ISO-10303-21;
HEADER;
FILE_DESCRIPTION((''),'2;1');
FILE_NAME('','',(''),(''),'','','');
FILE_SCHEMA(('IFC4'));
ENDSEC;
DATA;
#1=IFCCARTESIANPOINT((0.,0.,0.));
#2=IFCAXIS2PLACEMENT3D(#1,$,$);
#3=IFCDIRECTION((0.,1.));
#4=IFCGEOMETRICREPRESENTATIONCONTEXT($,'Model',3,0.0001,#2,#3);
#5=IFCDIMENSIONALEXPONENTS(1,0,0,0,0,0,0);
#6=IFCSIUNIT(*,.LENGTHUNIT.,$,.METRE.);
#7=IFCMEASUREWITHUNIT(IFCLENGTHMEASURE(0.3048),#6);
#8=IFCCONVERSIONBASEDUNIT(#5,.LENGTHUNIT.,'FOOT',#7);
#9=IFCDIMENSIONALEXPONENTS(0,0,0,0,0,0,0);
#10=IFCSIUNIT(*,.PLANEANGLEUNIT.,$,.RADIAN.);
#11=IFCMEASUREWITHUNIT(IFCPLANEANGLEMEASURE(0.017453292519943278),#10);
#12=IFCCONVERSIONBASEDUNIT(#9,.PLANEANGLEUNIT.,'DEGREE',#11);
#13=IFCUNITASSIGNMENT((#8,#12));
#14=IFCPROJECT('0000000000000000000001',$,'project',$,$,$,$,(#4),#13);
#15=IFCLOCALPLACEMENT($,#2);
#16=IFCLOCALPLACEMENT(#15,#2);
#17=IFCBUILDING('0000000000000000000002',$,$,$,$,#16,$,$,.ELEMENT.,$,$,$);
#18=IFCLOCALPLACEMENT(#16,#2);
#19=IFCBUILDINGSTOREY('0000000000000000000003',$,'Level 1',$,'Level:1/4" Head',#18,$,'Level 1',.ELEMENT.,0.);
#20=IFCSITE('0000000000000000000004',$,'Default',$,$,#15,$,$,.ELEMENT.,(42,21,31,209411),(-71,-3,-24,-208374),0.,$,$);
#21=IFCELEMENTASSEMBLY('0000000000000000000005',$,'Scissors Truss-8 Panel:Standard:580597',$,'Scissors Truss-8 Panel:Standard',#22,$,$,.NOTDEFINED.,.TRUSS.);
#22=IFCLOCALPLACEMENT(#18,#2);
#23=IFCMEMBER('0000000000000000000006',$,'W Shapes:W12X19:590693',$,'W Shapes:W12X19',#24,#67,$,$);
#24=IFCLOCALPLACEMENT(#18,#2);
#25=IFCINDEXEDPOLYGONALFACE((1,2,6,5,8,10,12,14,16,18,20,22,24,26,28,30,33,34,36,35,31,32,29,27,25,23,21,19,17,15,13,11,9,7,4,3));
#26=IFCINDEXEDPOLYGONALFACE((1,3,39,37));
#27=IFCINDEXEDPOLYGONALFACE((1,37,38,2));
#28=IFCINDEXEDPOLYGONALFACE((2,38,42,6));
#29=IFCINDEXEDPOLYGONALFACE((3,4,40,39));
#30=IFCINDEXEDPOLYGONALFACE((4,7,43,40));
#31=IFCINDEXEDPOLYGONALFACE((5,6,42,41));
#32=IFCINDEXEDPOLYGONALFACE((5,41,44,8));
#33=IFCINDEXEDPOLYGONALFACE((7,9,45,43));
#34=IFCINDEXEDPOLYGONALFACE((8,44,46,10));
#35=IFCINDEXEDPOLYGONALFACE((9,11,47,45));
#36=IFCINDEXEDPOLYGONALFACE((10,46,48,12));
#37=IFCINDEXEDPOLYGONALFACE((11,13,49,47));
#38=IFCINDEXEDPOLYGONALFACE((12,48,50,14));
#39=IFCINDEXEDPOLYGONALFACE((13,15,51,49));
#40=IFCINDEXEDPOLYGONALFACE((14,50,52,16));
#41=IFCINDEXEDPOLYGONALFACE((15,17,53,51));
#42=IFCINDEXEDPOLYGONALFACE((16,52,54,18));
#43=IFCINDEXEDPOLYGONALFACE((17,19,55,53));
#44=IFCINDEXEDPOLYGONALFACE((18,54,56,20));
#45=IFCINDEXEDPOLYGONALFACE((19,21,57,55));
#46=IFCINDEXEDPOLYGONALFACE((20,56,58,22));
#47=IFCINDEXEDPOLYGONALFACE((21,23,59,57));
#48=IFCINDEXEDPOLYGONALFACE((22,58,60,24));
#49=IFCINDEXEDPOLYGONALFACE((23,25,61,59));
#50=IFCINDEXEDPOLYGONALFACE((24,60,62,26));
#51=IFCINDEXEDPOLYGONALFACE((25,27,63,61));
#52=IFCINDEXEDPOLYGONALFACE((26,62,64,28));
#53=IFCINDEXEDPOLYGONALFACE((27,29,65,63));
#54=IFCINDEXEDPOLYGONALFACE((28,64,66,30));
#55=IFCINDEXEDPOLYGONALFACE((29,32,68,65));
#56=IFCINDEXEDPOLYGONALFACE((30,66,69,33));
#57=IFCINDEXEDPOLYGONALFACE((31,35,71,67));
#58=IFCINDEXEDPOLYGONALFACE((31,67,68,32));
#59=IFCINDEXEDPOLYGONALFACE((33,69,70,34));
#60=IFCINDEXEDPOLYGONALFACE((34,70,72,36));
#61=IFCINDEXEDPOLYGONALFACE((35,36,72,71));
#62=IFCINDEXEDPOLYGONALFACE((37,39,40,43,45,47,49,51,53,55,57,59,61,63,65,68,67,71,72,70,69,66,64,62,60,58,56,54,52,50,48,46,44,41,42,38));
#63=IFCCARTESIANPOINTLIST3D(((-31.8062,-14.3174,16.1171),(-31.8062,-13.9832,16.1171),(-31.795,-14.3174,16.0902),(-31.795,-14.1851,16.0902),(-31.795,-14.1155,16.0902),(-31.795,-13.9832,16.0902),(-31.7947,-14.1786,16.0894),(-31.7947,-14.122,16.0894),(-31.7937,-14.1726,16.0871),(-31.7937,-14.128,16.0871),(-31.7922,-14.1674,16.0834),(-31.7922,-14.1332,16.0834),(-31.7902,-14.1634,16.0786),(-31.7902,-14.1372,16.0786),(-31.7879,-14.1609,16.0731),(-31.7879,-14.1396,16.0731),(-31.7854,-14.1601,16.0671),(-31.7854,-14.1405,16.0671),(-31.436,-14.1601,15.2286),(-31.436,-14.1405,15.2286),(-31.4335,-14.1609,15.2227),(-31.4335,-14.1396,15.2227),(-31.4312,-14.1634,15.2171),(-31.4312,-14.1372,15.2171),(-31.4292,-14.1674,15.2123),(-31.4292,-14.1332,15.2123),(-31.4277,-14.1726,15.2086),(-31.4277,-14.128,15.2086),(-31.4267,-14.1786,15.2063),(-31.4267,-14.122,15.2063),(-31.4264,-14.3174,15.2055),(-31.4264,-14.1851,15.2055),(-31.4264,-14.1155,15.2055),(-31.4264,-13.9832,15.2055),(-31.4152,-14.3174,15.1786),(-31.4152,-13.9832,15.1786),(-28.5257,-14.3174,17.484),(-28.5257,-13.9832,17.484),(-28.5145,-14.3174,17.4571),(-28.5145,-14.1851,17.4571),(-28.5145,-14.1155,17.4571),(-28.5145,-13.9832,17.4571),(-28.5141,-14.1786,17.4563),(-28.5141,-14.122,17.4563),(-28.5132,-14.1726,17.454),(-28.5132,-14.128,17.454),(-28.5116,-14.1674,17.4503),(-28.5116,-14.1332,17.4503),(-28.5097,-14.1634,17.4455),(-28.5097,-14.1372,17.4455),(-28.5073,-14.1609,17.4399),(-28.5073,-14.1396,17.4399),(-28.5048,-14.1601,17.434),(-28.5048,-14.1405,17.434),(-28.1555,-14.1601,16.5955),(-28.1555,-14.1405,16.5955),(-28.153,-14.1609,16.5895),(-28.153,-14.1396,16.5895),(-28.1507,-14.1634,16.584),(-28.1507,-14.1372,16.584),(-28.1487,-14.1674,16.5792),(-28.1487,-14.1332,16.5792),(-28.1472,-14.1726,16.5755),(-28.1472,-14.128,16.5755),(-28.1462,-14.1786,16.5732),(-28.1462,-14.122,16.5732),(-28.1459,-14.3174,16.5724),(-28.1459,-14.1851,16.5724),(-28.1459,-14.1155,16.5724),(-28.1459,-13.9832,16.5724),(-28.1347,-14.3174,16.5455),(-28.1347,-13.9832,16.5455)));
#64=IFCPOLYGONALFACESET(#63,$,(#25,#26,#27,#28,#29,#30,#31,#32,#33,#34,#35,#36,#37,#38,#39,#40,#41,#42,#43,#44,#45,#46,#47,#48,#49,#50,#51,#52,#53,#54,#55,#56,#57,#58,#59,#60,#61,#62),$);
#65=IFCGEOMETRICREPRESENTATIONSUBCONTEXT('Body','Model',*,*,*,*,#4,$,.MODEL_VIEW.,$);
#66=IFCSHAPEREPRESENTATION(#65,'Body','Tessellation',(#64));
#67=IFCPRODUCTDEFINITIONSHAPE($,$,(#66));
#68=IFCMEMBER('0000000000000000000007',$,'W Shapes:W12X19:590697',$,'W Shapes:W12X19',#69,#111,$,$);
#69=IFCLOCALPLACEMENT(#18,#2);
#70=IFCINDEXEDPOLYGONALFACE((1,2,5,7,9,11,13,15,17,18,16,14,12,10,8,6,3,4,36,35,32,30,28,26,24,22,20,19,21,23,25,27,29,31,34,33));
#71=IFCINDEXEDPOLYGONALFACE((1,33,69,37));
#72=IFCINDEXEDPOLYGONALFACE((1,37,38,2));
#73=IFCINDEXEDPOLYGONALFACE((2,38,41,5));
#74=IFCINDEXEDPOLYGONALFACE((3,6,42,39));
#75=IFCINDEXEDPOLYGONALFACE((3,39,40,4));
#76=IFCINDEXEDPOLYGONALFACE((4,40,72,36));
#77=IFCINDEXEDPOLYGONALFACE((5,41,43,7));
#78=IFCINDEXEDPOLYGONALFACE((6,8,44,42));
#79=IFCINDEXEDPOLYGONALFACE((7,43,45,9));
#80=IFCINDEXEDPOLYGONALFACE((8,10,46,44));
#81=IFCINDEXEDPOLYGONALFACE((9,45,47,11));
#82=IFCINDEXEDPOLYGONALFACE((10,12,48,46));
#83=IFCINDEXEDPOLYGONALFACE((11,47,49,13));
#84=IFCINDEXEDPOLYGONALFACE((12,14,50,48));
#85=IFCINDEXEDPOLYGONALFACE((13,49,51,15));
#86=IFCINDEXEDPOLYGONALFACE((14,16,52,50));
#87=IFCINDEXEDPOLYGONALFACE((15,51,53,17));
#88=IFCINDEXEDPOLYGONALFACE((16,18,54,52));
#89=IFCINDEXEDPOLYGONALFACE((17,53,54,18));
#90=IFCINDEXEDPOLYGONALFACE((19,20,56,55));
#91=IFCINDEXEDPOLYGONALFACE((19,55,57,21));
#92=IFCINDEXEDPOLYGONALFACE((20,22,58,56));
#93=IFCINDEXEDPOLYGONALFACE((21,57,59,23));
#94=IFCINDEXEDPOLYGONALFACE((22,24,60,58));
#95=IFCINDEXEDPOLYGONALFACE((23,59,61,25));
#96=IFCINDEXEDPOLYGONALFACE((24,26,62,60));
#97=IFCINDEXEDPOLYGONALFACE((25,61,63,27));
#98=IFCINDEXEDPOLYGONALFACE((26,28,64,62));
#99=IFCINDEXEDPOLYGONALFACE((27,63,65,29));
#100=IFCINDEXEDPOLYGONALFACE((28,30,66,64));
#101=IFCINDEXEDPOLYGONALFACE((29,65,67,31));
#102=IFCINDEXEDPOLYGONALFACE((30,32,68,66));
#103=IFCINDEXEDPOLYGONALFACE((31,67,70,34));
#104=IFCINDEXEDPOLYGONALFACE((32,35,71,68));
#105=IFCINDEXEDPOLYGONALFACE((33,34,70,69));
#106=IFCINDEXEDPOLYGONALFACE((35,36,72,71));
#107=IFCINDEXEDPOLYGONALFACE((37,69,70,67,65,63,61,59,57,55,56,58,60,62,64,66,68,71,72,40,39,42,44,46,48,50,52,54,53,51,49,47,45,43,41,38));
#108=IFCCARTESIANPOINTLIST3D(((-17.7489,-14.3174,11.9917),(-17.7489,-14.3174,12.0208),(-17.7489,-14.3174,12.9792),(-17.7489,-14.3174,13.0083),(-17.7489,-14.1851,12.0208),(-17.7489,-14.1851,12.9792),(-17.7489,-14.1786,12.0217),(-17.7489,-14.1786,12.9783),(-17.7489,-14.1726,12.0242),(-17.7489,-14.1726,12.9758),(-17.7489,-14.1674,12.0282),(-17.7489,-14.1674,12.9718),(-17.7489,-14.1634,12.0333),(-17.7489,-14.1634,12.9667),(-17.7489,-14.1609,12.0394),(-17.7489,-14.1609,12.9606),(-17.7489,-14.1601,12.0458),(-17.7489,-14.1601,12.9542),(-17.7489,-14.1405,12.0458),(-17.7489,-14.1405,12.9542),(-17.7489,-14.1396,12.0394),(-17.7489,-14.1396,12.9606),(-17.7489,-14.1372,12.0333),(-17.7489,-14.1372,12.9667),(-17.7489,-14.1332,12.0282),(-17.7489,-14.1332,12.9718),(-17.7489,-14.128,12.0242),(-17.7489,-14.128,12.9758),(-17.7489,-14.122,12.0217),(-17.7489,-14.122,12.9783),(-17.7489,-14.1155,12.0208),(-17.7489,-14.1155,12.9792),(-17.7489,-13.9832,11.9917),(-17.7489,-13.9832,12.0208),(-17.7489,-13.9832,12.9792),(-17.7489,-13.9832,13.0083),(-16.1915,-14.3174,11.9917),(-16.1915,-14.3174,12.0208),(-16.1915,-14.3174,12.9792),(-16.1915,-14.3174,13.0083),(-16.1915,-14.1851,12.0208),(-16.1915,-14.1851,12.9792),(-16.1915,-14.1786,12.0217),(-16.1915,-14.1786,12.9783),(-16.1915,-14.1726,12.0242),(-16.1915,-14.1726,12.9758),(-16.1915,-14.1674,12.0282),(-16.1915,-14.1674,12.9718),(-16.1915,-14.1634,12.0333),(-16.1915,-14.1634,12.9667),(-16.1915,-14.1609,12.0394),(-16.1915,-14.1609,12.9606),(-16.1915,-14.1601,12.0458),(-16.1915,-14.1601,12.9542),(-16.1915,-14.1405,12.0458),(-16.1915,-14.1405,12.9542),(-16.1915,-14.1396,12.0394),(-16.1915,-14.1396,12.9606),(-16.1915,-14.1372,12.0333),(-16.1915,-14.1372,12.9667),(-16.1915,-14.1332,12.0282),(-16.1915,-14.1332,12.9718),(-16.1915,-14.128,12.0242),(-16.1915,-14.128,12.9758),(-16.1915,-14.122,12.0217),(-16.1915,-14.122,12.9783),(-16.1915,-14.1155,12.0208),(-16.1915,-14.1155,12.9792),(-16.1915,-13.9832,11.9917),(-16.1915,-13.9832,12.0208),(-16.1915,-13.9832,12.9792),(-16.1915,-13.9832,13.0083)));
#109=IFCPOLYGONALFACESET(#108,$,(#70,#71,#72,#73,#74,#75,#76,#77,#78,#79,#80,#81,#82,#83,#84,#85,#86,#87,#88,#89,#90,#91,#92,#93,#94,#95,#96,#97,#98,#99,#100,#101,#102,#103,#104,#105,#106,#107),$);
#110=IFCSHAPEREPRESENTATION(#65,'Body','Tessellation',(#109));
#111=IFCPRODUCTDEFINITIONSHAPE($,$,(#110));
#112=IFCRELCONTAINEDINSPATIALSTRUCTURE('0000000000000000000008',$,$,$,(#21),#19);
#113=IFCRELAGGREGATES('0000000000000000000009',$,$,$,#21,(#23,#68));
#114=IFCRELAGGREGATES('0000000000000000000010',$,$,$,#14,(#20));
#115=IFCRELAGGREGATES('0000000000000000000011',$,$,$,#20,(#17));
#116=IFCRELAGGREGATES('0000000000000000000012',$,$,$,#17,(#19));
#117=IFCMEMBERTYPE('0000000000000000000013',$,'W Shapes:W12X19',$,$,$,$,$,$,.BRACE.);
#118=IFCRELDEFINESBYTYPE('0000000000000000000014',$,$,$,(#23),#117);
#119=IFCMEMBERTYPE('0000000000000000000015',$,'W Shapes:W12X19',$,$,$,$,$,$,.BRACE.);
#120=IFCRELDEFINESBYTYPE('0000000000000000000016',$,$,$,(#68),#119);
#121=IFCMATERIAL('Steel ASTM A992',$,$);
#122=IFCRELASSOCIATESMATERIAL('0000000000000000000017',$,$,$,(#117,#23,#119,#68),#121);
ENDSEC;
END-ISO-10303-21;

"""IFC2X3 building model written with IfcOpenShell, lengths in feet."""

from ifc_helpers import new_model, entity, si_unit, converted_unit, direction, frame, frame_2d, origin, place, context, subcontext, project, spatial, polyline, circle_curve, parameter, trimmed, segment, composite_curve, outline, extrude, source, transform, mapped, material, type_object, type_shapes, element, aggregate, save


model = new_model("IFC2X3")

# Units and contexts
model_context = context("Model", 3, precision=0.0001, world=origin(), true_north=direction((0.0, 1.0)))
body_context = subcontext(model_context, "Body", "Model", "MODEL_VIEW")
ifc_project = project(units=[converted_unit("LENGTHUNIT", "FOOT", entity("IfcLengthMeasure", 0.3048), si_unit("LENGTHUNIT", "METRE"), dimensions=[1, 0, 0, 0, 0, 0, 0]), converted_unit("PLANEANGLEUNIT", "DEGREE", entity("IfcPlaneAngleMeasure", 0.017453292519943278), si_unit("PLANEANGLEUNIT", "RADIAN"), dimensions=[0, 0, 0, 0, 0, 0, 0])], contexts=[model_context])

# Site, building, storey
site_placement = place(None, origin())
site = spatial("IfcSite", under=ifc_project, at=site_placement, Name="Default", CompositionType="ELEMENT", RefLatitude=(42, 21, 31, 209411), RefLongitude=(-71, -3, -24, -208374), RefElevation=0.0)
building_placement = place(site_placement, origin())
building = spatial("IfcBuilding", under=site, at=building_placement, CompositionType="ELEMENT")
storey_placement = place(building_placement, origin())
storey = spatial("IfcBuildingStorey", under=building, at=storey_placement, Name="Level 1", ObjectType="Level:1/4\" Head", LongName="Level 1", CompositionType="ELEMENT", Elevation=0.0)

# Element assembly, members
assembly_placement = place(storey_placement, origin())
assembly = element("IfcElementAssembly", 1, at=assembly_placement, inside=storey, Name="Scissors Truss-8 Panel:Standard:580597", ObjectType="Scissors Truss-8 Panel:Standard", AssemblyPlace="NOTDEFINED", PredefinedType="TRUSS")
ifc_material = material(Name="Steel ASTM A992")
member_type_1 = type_object("IfcMemberType", Name="W Shapes:W12X19", PredefinedType="BRACE", material=ifc_material)
shared_shape_1 = source(origin(), body_context, "Body", "SweptSolid", [
    extrude(outline(composite_curve([segment(polyline([(-0.1671, -0.4792), (-0.1671, -0.5083)]), True, "CONTINUOUS"), segment(polyline([(-0.1671, -0.5083), (0.1671, -0.5083)]), True, "CONTINUOUS"), segment(polyline([(0.1671, -0.5083), (0.1671, -0.4792)]), True, "CONTINUOUS"), segment(polyline([(0.1671, -0.4792), (0.0348, -0.4792)]), True, "CONTINUOUS"), segment(trimmed(circle_curve(frame_2d((0.0348, -0.4542), x_axis=(1.0, 0.0)), 0.025), [parameter(180.0)], [parameter(270.0)], True, "PARAMETER"), False, "CONTINUOUS"), segment(polyline([(0.0098, -0.4542), (0.0098, 0.4542)]), True, "CONTINUOUS"), segment(trimmed(circle_curve(frame_2d((0.0348, 0.4542), x_axis=(1.0, 0.0)), 0.025), [parameter(90.0)], [parameter(180.0)], True, "PARAMETER"), False, "CONTINUOUS"), segment(polyline([(0.0348, 0.4792), (0.1671, 0.4792)]), True, "CONTINUOUS"), segment(polyline([(0.1671, 0.4792), (0.1671, 0.5083)]), True, "CONTINUOUS"), segment(polyline([(0.1671, 0.5083), (-0.1671, 0.5083)]), True, "CONTINUOUS"), segment(polyline([(-0.1671, 0.5083), (-0.1671, 0.4792)]), True, "CONTINUOUS"), segment(polyline([(-0.1671, 0.4792), (-0.0348, 0.4792)]), True, "CONTINUOUS"), segment(trimmed(circle_curve(frame_2d((-0.0348, 0.4542), x_axis=(1.0, 0.0)), 0.025), [parameter(360.0)], [parameter(90.0)], True, "PARAMETER"), False, "CONTINUOUS"), segment(polyline([(-0.0098, 0.4542), (-0.0098, -0.4542)]), True, "CONTINUOUS"), segment(trimmed(circle_curve(frame_2d((-0.0348, -0.4542), x_axis=(1.0, 0.0)), 0.025), [parameter(270.0)], [parameter(360.0)], True, "PARAMETER"), False, "CONTINUOUS"), segment(polyline([(-0.0348, -0.4792), (-0.1671, -0.4792)]), True, "CONTINUOUS")], self_intersect=False)), frame((-1.5656, 0.0, 0.0), z_axis=(-1.0, 0.0, 0.0), x_axis=(0.0, -1.0, 0.0)), (0.0, 0.0, -1.0), 3.5539),
])
type_shapes(member_type_1, [shared_shape_1])
member_1_placement = place(assembly_placement, frame((-30.1655, -14.1503, 16.25), z_axis=(0.384615, 0.0, -0.923077), x_axis=(0.923077, 0.0, 0.384615)))
member_1 = element("IfcMember", 2, at=member_1_placement, type_object=member_type_1, material=ifc_material, Name="W Shapes:W12X19:590693", ObjectType="W Shapes:W12X19", context=body_context, shape_type="MappedRepresentation", body=[
    mapped(shared_shape_1, transform((0.0, 0.0, 0.0), scale=1.0)),
])
member_type_2 = type_object("IfcMemberType", Name="W Shapes:W12X19", PredefinedType="BRACE", material=ifc_material)
shared_shape_2 = source(origin(), body_context, "Body", "SweptSolid", [
    extrude(outline(composite_curve([segment(polyline([(0.4792, -0.1671), (0.5083, -0.1671)]), True, "CONTINUOUS"), segment(polyline([(0.5083, -0.1671), (0.5083, 0.1671)]), True, "CONTINUOUS"), segment(polyline([(0.5083, 0.1671), (0.4792, 0.1671)]), True, "CONTINUOUS"), segment(polyline([(0.4792, 0.1671), (0.4792, 0.0348)]), True, "CONTINUOUS"), segment(trimmed(circle_curve(frame_2d((0.4542, 0.0348), x_axis=(0.0, 1.0)), 0.025), [parameter(180.0)], [parameter(270.0)], True, "PARAMETER"), False, "CONTINUOUS"), segment(polyline([(0.4542, 0.0098), (-0.4542, 0.0098)]), True, "CONTINUOUS"), segment(trimmed(circle_curve(frame_2d((-0.4542, 0.0348), x_axis=(0.0, 1.0)), 0.025), [parameter(90.0)], [parameter(180.0)], True, "PARAMETER"), False, "CONTINUOUS"), segment(polyline([(-0.4792, 0.0348), (-0.4792, 0.1671)]), True, "CONTINUOUS"), segment(polyline([(-0.4792, 0.1671), (-0.5083, 0.1671)]), True, "CONTINUOUS"), segment(polyline([(-0.5083, 0.1671), (-0.5083, -0.1671)]), True, "CONTINUOUS"), segment(polyline([(-0.5083, -0.1671), (-0.4792, -0.1671)]), True, "CONTINUOUS"), segment(polyline([(-0.4792, -0.1671), (-0.4792, -0.0348)]), True, "CONTINUOUS"), segment(trimmed(circle_curve(frame_2d((-0.4542, -0.0348), x_axis=(0.0, 1.0)), 0.025), [parameter(360.0)], [parameter(90.0)], True, "PARAMETER"), False, "CONTINUOUS"), segment(polyline([(-0.4542, -0.0098), (0.4542, -0.0098)]), True, "CONTINUOUS"), segment(trimmed(circle_curve(frame_2d((0.4542, -0.0348), x_axis=(0.0, 1.0)), 0.025), [parameter(270.0)], [parameter(360.0)], True, "PARAMETER"), False, "CONTINUOUS"), segment(polyline([(0.4792, -0.0348), (0.4792, -0.1671)]), True, "CONTINUOUS")], self_intersect=False)), frame((0.4167, 0.0, 0.0), z_axis=(1.0, 0.0, 0.0), x_axis=(0.0, 0.0, -1.0)), (0.0, 0.0, 1.0), 1.5574),
])
type_shapes(member_type_2, [shared_shape_2])
member_2_placement = place(assembly_placement, frame((-18.1655, -14.1503, 12.5), z_axis=(0.0, 0.0, -1.0), x_axis=(1.0, 0.0, 0.0)))
member_2 = element("IfcMember", 3, at=member_2_placement, type_object=member_type_2, material=ifc_material, Name="W Shapes:W12X19:590697", ObjectType="W Shapes:W12X19", context=body_context, shape_type="MappedRepresentation", body=[
    mapped(shared_shape_2, transform((0.0, 0.0, 0.0), scale=1.0)),
])
aggregate(assembly, [member_1, member_2])

save(model, "model.ifc")
